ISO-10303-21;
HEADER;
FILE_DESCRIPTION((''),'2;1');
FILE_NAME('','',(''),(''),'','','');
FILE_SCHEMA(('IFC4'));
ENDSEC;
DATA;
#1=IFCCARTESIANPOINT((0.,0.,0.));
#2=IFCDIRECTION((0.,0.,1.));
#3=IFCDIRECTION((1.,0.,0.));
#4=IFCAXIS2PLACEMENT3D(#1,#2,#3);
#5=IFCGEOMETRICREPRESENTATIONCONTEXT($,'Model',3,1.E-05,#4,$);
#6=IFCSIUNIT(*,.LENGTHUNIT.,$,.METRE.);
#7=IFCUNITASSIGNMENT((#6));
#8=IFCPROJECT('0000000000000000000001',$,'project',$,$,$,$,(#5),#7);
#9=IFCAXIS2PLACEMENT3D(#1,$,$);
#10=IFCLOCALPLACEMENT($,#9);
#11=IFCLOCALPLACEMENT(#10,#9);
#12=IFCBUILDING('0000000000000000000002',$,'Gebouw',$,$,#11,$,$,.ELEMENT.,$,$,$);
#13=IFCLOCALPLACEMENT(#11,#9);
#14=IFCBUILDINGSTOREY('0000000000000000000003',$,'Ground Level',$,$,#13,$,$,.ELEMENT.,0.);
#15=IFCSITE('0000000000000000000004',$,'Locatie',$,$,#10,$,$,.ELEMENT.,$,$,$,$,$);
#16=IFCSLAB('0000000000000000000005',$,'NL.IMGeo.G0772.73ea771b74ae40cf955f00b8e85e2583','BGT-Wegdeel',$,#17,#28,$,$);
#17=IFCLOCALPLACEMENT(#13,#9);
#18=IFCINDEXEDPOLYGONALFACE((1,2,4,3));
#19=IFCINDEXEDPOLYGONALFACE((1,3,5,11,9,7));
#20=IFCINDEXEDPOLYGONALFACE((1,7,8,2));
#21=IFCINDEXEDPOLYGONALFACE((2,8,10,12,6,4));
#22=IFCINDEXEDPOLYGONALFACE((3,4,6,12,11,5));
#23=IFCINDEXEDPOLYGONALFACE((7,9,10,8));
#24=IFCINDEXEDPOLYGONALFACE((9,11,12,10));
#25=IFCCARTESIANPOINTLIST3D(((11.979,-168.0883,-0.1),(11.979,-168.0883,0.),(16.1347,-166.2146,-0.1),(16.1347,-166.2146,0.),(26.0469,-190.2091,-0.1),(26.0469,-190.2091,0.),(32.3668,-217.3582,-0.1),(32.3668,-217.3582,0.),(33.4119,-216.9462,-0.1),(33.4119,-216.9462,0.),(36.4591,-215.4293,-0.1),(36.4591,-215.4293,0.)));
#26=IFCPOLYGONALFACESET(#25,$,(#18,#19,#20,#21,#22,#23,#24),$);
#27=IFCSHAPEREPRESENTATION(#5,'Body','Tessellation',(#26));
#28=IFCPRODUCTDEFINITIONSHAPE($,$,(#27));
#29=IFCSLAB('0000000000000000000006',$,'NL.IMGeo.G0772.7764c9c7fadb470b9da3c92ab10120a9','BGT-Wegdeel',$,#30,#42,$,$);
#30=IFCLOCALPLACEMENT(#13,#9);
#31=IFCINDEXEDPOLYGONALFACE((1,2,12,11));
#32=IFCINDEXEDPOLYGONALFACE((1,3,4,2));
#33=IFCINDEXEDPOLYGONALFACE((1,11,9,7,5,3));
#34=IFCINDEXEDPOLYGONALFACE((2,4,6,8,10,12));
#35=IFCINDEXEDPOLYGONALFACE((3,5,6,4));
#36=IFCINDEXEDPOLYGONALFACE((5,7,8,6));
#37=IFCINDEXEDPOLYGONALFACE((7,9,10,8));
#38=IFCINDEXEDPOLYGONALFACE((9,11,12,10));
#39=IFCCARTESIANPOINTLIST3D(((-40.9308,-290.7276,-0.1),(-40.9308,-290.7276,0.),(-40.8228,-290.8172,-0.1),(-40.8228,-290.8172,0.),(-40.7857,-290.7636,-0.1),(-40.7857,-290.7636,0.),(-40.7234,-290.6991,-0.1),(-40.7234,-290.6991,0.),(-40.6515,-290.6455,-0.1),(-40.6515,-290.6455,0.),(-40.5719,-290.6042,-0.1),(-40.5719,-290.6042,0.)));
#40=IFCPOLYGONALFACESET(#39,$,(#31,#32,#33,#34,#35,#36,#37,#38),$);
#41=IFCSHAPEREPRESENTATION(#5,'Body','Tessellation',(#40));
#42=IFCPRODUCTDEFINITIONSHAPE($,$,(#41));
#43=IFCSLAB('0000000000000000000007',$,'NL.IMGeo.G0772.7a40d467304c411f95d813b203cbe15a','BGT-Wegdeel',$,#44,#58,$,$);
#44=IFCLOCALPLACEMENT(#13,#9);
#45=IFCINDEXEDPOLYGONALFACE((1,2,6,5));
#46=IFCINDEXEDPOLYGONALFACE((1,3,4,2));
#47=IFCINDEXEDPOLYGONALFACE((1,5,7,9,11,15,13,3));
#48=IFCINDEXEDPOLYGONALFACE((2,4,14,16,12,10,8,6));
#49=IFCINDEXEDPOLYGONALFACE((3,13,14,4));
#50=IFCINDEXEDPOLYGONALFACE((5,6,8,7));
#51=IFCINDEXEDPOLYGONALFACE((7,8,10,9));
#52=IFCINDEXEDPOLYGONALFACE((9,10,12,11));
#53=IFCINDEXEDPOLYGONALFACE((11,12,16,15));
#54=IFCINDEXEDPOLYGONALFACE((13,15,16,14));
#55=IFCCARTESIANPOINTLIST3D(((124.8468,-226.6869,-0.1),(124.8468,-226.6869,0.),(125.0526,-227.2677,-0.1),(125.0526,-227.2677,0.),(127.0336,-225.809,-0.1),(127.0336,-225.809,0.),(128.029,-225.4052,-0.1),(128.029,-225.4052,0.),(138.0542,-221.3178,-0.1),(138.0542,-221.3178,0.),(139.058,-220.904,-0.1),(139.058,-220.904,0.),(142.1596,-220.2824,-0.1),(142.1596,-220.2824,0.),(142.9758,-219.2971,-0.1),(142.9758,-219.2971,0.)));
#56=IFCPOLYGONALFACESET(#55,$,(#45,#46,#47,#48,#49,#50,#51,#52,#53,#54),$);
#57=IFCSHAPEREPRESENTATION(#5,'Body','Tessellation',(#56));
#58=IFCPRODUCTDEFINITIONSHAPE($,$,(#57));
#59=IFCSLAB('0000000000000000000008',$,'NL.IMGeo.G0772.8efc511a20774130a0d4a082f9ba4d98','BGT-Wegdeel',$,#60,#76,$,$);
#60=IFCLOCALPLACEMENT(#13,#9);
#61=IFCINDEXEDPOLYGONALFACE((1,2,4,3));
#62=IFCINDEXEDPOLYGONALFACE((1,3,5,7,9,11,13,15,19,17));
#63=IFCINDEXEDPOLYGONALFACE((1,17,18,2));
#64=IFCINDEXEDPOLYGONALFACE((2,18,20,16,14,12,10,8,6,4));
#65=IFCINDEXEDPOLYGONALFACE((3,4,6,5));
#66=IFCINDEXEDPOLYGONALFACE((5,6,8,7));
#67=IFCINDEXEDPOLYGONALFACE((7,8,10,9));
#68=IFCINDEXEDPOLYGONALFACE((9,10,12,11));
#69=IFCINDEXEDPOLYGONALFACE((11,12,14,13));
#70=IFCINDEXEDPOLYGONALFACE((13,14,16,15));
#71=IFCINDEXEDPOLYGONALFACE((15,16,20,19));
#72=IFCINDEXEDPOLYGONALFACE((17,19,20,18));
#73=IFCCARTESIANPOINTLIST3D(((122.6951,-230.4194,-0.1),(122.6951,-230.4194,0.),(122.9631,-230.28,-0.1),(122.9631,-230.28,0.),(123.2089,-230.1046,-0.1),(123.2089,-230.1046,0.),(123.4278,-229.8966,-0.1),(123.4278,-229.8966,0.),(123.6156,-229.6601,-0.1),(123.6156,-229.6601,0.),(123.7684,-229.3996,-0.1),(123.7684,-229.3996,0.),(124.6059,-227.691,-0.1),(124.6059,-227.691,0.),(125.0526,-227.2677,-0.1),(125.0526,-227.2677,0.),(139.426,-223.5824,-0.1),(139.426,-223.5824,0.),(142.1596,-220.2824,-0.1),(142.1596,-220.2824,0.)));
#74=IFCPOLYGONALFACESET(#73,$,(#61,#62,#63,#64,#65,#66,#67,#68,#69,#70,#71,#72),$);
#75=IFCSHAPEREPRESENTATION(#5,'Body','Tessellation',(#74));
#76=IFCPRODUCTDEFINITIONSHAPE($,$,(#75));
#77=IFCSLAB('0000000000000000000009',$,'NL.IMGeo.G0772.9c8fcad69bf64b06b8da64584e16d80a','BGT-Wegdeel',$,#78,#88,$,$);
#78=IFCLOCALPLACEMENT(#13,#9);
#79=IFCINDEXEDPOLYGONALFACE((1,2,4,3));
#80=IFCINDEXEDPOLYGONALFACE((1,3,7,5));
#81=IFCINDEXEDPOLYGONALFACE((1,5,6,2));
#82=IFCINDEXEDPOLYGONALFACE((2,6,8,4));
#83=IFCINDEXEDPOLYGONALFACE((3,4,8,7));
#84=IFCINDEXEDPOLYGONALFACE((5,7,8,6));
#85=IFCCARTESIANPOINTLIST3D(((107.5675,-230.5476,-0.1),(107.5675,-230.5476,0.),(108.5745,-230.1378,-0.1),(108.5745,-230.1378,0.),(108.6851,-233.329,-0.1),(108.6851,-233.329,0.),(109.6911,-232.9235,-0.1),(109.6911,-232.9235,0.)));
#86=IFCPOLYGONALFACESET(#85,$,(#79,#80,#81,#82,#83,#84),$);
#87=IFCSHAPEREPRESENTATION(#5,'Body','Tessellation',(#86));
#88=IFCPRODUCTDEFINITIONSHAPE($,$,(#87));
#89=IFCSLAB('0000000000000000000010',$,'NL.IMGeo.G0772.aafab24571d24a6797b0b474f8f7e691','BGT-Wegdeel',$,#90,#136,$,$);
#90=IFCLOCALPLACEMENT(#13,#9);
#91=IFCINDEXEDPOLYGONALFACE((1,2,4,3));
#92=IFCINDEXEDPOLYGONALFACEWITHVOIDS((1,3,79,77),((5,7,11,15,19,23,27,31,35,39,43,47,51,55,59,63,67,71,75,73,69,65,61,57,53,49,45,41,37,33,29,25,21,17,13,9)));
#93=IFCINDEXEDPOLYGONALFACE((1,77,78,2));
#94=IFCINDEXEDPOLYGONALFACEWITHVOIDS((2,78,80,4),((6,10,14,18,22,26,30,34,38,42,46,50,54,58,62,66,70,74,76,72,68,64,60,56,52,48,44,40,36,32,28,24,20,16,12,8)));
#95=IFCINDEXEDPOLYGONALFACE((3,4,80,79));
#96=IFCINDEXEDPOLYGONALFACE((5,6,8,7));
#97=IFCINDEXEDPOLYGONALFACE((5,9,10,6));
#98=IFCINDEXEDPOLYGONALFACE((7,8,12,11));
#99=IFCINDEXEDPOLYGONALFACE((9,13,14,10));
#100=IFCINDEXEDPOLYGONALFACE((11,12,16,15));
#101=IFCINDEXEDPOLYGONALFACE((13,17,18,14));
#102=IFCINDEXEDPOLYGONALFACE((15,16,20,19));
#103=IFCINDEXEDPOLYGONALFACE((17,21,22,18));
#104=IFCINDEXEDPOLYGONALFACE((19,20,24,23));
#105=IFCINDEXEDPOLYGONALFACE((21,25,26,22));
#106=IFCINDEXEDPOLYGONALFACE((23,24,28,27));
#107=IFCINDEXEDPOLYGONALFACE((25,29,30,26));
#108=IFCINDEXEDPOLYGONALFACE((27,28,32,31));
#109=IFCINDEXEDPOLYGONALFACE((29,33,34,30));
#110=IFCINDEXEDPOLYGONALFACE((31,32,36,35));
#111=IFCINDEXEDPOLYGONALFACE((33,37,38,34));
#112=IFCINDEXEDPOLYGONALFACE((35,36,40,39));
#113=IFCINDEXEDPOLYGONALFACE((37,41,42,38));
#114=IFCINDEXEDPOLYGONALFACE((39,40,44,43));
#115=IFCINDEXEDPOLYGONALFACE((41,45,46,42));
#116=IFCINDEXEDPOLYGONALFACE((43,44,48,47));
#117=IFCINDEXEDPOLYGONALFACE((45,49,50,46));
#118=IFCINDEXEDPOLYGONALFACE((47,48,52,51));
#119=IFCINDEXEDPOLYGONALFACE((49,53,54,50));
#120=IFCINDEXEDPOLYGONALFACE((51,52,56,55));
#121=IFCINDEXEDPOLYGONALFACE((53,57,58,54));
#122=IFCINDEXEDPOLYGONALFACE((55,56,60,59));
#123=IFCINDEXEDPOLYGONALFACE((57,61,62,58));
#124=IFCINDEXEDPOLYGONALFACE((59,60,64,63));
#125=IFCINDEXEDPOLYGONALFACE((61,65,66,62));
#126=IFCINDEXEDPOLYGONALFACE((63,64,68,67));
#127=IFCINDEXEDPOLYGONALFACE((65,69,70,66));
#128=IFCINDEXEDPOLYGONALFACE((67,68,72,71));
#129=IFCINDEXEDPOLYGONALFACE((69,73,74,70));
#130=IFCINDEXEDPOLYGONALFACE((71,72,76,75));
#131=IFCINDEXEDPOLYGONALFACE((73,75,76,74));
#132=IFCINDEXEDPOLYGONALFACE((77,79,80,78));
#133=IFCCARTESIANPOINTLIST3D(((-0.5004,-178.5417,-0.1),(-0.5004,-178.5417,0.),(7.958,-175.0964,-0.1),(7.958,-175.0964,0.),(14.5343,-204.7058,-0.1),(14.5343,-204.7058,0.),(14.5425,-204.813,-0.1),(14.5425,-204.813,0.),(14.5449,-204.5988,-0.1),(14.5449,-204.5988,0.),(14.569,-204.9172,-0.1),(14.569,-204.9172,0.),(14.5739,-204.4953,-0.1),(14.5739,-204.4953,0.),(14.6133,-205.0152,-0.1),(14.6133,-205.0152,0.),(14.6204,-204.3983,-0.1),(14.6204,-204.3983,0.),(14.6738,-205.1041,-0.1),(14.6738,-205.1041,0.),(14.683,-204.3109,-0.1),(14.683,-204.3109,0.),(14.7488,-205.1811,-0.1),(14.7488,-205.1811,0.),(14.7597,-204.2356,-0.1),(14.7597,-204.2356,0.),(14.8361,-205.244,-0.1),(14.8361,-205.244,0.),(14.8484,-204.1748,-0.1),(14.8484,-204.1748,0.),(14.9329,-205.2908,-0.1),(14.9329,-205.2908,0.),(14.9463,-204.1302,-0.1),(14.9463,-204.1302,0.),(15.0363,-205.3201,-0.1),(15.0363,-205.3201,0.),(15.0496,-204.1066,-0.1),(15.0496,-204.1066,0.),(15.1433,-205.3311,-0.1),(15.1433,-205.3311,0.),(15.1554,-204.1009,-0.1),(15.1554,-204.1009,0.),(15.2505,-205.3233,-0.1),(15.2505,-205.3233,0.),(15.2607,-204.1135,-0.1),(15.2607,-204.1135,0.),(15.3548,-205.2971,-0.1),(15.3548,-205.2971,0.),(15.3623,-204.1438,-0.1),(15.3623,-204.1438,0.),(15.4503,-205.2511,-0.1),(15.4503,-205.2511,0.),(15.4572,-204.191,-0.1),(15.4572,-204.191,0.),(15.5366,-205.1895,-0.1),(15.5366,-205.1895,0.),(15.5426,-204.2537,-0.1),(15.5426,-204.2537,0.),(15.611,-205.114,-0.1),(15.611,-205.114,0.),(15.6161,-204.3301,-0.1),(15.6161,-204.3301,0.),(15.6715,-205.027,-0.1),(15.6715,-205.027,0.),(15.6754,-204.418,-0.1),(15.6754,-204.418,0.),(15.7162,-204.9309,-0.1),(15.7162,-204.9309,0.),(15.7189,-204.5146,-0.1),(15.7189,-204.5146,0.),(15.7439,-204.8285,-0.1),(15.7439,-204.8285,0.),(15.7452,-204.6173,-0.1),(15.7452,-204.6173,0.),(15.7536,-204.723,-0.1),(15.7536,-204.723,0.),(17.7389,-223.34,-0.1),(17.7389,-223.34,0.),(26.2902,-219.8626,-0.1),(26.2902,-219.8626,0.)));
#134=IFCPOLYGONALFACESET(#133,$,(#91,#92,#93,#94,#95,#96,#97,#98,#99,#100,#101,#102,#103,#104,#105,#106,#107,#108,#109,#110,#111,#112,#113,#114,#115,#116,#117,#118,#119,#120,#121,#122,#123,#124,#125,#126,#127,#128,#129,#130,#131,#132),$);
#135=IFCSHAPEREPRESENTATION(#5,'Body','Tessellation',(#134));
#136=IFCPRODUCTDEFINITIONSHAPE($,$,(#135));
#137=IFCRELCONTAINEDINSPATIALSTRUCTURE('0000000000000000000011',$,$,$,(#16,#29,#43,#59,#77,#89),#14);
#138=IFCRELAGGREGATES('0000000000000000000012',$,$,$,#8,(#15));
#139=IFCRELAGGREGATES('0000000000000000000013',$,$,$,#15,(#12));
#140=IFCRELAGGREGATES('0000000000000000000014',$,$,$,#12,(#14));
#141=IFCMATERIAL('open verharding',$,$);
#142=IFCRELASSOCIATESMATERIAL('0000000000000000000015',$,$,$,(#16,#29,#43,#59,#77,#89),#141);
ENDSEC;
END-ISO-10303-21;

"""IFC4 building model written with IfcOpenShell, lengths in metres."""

from ifc_helpers import new_model, si_unit, frame, origin, origin_with_axes, place, context, project, spatial, polyline, outline, extrude, material, element, save


model = new_model("IFC4")

# Units and contexts
model_context = context("Model", 3, precision=1e-05, world=origin_with_axes())
ifc_project = project(units=[si_unit("LENGTHUNIT", "METRE")], contexts=[model_context])

# Site, building, storey
site_placement = place(None, origin())
site = spatial("IfcSite", under=ifc_project, at=site_placement, Name="Locatie", CompositionType="ELEMENT")
building_placement = place(site_placement, origin())
building = spatial("IfcBuilding", under=site, at=building_placement, Name="Gebouw", CompositionType="ELEMENT")
storey_placement = place(building_placement, origin())
storey = spatial("IfcBuildingStorey", under=building, at=storey_placement, Name="Ground Level", CompositionType="ELEMENT", Elevation=0.0)

# Slabs
ifc_material = material(Name="open verharding")
slab_1_placement = place(storey_placement, origin())
element("IfcSlab", 1, at=slab_1_placement, inside=storey, material=ifc_material, Name="NL.IMGeo.G0772.73ea771b74ae40cf955f00b8e85e2583", Description="BGT-Wegdeel", context=model_context, shape_type="SweptSolid", body=[
    extrude(outline(polyline([(33.4119, -216.9462), (32.3668, -217.3582), (11.979, -168.0883), (16.1347, -166.2146), (26.0469, -190.2091), (36.4591, -215.4293), (33.4119, -216.9462)])), frame((0.0, 0.0, -0.1), z_axis=(0.0, 0.0, 1.0), x_axis=(1.0, 0.0, 0.0)), (0.0, 0.0, 1.0), 0.1),
])
slab_2_placement = place(storey_placement, origin())
element("IfcSlab", 2, at=slab_2_placement, inside=storey, material=ifc_material, Name="NL.IMGeo.G0772.7764c9c7fadb470b9da3c92ab10120a9", Description="BGT-Wegdeel", context=model_context, shape_type="SweptSolid", body=[
    extrude(outline(polyline([(-40.5719, -290.6042), (-40.6515, -290.6455), (-40.7234, -290.6991), (-40.7857, -290.7636), (-40.8228, -290.8172), (-40.9308, -290.7276), (-40.5719, -290.6042)])), frame((0.0, 0.0, -0.1), z_axis=(0.0, 0.0, 1.0), x_axis=(1.0, 0.0, 0.0)), (0.0, 0.0, 1.0), 0.1),
])
slab_3_placement = place(storey_placement, origin())
element("IfcSlab", 3, at=slab_3_placement, inside=storey, material=ifc_material, Name="NL.IMGeo.G0772.7a40d467304c411f95d813b203cbe15a", Description="BGT-Wegdeel", context=model_context, shape_type="SweptSolid", body=[
    extrude(outline(polyline([(125.0526, -227.2677), (124.8468, -226.6869), (127.0336, -225.809), (128.029, -225.4052), (138.0542, -221.3178), (139.058, -220.904), (142.9758, -219.2971), (142.1596, -220.2824), (125.0526, -227.2677)])), frame((0.0, 0.0, -0.1), z_axis=(0.0, 0.0, 1.0), x_axis=(1.0, 0.0, 0.0)), (0.0, 0.0, 1.0), 0.1),
])
slab_4_placement = place(storey_placement, origin())
element("IfcSlab", 4, at=slab_4_placement, inside=storey, material=ifc_material, Name="NL.IMGeo.G0772.8efc511a20774130a0d4a082f9ba4d98", Description="BGT-Wegdeel", context=model_context, shape_type="SweptSolid", body=[
    extrude(outline(polyline([(122.6951, -230.4194), (122.9631, -230.28), (123.2089, -230.1046), (123.4278, -229.8966), (123.6156, -229.6601), (123.7684, -229.3996), (124.6059, -227.691), (125.0526, -227.2677), (142.1596, -220.2824), (139.426, -223.5824), (122.6951, -230.4194)])), frame((0.0, 0.0, -0.1), z_axis=(0.0, 0.0, 1.0), x_axis=(1.0, 0.0, 0.0)), (0.0, 0.0, 1.0), 0.1),
])
slab_5_placement = place(storey_placement, origin())
element("IfcSlab", 5, at=slab_5_placement, inside=storey, material=ifc_material, Name="NL.IMGeo.G0772.9c8fcad69bf64b06b8da64584e16d80a", Description="BGT-Wegdeel", context=model_context, shape_type="SweptSolid", body=[
    extrude(outline(polyline([(108.5745, -230.1378), (109.6911, -232.9235), (108.6851, -233.329), (107.5675, -230.5476), (108.5745, -230.1378)])), frame((0.0, 0.0, -0.1), z_axis=(0.0, 0.0, 1.0), x_axis=(1.0, 0.0, 0.0)), (0.0, 0.0, 1.0), 0.1),
])
slab_6_placement = place(storey_placement, origin())
element("IfcSlab", 6, at=slab_6_placement, inside=storey, material=ifc_material, Name="NL.IMGeo.G0772.aafab24571d24a6797b0b474f8f7e691", Description="BGT-Wegdeel", context=model_context, shape_type="SweptSolid", body=[
    extrude(outline(polyline([(-0.5004, -178.5417), (7.958, -175.0964), (26.2902, -219.8626), (17.7389, -223.34), (-0.5004, -178.5417)]), holes=[polyline([(14.8484, -204.1748), (14.7597, -204.2356), (14.683, -204.3109), (14.6204, -204.3983), (14.5739, -204.4953), (14.5449, -204.5988), (14.5343, -204.7058), (14.5425, -204.813), (14.569, -204.9172), (14.6133, -205.0152), (14.6738, -205.1041), (14.7488, -205.1811), (14.8361, -205.244), (14.9329, -205.2908), (15.0363, -205.3201), (15.1433, -205.3311), (15.2505, -205.3233), (15.3548, -205.2971), (15.4503, -205.2511), (15.5366, -205.1895), (15.611, -205.114), (15.6715, -205.027), (15.7162, -204.9309), (15.7439, -204.8285), (15.7536, -204.723), (15.7452, -204.6173), (15.7189, -204.5146), (15.6754, -204.418), (15.6161, -204.3301), (15.5426, -204.2537), (15.4572, -204.191), (15.3623, -204.1438), (15.2607, -204.1135), (15.1554, -204.1009), (15.0496, -204.1066), (14.9463, -204.1302), (14.8484, -204.1748)])]), frame((0.0, 0.0, -0.1), z_axis=(0.0, 0.0, 1.0), x_axis=(1.0, 0.0, 0.0)), (0.0, 0.0, 1.0), 0.1),
])

save(model, "model.ifc")
